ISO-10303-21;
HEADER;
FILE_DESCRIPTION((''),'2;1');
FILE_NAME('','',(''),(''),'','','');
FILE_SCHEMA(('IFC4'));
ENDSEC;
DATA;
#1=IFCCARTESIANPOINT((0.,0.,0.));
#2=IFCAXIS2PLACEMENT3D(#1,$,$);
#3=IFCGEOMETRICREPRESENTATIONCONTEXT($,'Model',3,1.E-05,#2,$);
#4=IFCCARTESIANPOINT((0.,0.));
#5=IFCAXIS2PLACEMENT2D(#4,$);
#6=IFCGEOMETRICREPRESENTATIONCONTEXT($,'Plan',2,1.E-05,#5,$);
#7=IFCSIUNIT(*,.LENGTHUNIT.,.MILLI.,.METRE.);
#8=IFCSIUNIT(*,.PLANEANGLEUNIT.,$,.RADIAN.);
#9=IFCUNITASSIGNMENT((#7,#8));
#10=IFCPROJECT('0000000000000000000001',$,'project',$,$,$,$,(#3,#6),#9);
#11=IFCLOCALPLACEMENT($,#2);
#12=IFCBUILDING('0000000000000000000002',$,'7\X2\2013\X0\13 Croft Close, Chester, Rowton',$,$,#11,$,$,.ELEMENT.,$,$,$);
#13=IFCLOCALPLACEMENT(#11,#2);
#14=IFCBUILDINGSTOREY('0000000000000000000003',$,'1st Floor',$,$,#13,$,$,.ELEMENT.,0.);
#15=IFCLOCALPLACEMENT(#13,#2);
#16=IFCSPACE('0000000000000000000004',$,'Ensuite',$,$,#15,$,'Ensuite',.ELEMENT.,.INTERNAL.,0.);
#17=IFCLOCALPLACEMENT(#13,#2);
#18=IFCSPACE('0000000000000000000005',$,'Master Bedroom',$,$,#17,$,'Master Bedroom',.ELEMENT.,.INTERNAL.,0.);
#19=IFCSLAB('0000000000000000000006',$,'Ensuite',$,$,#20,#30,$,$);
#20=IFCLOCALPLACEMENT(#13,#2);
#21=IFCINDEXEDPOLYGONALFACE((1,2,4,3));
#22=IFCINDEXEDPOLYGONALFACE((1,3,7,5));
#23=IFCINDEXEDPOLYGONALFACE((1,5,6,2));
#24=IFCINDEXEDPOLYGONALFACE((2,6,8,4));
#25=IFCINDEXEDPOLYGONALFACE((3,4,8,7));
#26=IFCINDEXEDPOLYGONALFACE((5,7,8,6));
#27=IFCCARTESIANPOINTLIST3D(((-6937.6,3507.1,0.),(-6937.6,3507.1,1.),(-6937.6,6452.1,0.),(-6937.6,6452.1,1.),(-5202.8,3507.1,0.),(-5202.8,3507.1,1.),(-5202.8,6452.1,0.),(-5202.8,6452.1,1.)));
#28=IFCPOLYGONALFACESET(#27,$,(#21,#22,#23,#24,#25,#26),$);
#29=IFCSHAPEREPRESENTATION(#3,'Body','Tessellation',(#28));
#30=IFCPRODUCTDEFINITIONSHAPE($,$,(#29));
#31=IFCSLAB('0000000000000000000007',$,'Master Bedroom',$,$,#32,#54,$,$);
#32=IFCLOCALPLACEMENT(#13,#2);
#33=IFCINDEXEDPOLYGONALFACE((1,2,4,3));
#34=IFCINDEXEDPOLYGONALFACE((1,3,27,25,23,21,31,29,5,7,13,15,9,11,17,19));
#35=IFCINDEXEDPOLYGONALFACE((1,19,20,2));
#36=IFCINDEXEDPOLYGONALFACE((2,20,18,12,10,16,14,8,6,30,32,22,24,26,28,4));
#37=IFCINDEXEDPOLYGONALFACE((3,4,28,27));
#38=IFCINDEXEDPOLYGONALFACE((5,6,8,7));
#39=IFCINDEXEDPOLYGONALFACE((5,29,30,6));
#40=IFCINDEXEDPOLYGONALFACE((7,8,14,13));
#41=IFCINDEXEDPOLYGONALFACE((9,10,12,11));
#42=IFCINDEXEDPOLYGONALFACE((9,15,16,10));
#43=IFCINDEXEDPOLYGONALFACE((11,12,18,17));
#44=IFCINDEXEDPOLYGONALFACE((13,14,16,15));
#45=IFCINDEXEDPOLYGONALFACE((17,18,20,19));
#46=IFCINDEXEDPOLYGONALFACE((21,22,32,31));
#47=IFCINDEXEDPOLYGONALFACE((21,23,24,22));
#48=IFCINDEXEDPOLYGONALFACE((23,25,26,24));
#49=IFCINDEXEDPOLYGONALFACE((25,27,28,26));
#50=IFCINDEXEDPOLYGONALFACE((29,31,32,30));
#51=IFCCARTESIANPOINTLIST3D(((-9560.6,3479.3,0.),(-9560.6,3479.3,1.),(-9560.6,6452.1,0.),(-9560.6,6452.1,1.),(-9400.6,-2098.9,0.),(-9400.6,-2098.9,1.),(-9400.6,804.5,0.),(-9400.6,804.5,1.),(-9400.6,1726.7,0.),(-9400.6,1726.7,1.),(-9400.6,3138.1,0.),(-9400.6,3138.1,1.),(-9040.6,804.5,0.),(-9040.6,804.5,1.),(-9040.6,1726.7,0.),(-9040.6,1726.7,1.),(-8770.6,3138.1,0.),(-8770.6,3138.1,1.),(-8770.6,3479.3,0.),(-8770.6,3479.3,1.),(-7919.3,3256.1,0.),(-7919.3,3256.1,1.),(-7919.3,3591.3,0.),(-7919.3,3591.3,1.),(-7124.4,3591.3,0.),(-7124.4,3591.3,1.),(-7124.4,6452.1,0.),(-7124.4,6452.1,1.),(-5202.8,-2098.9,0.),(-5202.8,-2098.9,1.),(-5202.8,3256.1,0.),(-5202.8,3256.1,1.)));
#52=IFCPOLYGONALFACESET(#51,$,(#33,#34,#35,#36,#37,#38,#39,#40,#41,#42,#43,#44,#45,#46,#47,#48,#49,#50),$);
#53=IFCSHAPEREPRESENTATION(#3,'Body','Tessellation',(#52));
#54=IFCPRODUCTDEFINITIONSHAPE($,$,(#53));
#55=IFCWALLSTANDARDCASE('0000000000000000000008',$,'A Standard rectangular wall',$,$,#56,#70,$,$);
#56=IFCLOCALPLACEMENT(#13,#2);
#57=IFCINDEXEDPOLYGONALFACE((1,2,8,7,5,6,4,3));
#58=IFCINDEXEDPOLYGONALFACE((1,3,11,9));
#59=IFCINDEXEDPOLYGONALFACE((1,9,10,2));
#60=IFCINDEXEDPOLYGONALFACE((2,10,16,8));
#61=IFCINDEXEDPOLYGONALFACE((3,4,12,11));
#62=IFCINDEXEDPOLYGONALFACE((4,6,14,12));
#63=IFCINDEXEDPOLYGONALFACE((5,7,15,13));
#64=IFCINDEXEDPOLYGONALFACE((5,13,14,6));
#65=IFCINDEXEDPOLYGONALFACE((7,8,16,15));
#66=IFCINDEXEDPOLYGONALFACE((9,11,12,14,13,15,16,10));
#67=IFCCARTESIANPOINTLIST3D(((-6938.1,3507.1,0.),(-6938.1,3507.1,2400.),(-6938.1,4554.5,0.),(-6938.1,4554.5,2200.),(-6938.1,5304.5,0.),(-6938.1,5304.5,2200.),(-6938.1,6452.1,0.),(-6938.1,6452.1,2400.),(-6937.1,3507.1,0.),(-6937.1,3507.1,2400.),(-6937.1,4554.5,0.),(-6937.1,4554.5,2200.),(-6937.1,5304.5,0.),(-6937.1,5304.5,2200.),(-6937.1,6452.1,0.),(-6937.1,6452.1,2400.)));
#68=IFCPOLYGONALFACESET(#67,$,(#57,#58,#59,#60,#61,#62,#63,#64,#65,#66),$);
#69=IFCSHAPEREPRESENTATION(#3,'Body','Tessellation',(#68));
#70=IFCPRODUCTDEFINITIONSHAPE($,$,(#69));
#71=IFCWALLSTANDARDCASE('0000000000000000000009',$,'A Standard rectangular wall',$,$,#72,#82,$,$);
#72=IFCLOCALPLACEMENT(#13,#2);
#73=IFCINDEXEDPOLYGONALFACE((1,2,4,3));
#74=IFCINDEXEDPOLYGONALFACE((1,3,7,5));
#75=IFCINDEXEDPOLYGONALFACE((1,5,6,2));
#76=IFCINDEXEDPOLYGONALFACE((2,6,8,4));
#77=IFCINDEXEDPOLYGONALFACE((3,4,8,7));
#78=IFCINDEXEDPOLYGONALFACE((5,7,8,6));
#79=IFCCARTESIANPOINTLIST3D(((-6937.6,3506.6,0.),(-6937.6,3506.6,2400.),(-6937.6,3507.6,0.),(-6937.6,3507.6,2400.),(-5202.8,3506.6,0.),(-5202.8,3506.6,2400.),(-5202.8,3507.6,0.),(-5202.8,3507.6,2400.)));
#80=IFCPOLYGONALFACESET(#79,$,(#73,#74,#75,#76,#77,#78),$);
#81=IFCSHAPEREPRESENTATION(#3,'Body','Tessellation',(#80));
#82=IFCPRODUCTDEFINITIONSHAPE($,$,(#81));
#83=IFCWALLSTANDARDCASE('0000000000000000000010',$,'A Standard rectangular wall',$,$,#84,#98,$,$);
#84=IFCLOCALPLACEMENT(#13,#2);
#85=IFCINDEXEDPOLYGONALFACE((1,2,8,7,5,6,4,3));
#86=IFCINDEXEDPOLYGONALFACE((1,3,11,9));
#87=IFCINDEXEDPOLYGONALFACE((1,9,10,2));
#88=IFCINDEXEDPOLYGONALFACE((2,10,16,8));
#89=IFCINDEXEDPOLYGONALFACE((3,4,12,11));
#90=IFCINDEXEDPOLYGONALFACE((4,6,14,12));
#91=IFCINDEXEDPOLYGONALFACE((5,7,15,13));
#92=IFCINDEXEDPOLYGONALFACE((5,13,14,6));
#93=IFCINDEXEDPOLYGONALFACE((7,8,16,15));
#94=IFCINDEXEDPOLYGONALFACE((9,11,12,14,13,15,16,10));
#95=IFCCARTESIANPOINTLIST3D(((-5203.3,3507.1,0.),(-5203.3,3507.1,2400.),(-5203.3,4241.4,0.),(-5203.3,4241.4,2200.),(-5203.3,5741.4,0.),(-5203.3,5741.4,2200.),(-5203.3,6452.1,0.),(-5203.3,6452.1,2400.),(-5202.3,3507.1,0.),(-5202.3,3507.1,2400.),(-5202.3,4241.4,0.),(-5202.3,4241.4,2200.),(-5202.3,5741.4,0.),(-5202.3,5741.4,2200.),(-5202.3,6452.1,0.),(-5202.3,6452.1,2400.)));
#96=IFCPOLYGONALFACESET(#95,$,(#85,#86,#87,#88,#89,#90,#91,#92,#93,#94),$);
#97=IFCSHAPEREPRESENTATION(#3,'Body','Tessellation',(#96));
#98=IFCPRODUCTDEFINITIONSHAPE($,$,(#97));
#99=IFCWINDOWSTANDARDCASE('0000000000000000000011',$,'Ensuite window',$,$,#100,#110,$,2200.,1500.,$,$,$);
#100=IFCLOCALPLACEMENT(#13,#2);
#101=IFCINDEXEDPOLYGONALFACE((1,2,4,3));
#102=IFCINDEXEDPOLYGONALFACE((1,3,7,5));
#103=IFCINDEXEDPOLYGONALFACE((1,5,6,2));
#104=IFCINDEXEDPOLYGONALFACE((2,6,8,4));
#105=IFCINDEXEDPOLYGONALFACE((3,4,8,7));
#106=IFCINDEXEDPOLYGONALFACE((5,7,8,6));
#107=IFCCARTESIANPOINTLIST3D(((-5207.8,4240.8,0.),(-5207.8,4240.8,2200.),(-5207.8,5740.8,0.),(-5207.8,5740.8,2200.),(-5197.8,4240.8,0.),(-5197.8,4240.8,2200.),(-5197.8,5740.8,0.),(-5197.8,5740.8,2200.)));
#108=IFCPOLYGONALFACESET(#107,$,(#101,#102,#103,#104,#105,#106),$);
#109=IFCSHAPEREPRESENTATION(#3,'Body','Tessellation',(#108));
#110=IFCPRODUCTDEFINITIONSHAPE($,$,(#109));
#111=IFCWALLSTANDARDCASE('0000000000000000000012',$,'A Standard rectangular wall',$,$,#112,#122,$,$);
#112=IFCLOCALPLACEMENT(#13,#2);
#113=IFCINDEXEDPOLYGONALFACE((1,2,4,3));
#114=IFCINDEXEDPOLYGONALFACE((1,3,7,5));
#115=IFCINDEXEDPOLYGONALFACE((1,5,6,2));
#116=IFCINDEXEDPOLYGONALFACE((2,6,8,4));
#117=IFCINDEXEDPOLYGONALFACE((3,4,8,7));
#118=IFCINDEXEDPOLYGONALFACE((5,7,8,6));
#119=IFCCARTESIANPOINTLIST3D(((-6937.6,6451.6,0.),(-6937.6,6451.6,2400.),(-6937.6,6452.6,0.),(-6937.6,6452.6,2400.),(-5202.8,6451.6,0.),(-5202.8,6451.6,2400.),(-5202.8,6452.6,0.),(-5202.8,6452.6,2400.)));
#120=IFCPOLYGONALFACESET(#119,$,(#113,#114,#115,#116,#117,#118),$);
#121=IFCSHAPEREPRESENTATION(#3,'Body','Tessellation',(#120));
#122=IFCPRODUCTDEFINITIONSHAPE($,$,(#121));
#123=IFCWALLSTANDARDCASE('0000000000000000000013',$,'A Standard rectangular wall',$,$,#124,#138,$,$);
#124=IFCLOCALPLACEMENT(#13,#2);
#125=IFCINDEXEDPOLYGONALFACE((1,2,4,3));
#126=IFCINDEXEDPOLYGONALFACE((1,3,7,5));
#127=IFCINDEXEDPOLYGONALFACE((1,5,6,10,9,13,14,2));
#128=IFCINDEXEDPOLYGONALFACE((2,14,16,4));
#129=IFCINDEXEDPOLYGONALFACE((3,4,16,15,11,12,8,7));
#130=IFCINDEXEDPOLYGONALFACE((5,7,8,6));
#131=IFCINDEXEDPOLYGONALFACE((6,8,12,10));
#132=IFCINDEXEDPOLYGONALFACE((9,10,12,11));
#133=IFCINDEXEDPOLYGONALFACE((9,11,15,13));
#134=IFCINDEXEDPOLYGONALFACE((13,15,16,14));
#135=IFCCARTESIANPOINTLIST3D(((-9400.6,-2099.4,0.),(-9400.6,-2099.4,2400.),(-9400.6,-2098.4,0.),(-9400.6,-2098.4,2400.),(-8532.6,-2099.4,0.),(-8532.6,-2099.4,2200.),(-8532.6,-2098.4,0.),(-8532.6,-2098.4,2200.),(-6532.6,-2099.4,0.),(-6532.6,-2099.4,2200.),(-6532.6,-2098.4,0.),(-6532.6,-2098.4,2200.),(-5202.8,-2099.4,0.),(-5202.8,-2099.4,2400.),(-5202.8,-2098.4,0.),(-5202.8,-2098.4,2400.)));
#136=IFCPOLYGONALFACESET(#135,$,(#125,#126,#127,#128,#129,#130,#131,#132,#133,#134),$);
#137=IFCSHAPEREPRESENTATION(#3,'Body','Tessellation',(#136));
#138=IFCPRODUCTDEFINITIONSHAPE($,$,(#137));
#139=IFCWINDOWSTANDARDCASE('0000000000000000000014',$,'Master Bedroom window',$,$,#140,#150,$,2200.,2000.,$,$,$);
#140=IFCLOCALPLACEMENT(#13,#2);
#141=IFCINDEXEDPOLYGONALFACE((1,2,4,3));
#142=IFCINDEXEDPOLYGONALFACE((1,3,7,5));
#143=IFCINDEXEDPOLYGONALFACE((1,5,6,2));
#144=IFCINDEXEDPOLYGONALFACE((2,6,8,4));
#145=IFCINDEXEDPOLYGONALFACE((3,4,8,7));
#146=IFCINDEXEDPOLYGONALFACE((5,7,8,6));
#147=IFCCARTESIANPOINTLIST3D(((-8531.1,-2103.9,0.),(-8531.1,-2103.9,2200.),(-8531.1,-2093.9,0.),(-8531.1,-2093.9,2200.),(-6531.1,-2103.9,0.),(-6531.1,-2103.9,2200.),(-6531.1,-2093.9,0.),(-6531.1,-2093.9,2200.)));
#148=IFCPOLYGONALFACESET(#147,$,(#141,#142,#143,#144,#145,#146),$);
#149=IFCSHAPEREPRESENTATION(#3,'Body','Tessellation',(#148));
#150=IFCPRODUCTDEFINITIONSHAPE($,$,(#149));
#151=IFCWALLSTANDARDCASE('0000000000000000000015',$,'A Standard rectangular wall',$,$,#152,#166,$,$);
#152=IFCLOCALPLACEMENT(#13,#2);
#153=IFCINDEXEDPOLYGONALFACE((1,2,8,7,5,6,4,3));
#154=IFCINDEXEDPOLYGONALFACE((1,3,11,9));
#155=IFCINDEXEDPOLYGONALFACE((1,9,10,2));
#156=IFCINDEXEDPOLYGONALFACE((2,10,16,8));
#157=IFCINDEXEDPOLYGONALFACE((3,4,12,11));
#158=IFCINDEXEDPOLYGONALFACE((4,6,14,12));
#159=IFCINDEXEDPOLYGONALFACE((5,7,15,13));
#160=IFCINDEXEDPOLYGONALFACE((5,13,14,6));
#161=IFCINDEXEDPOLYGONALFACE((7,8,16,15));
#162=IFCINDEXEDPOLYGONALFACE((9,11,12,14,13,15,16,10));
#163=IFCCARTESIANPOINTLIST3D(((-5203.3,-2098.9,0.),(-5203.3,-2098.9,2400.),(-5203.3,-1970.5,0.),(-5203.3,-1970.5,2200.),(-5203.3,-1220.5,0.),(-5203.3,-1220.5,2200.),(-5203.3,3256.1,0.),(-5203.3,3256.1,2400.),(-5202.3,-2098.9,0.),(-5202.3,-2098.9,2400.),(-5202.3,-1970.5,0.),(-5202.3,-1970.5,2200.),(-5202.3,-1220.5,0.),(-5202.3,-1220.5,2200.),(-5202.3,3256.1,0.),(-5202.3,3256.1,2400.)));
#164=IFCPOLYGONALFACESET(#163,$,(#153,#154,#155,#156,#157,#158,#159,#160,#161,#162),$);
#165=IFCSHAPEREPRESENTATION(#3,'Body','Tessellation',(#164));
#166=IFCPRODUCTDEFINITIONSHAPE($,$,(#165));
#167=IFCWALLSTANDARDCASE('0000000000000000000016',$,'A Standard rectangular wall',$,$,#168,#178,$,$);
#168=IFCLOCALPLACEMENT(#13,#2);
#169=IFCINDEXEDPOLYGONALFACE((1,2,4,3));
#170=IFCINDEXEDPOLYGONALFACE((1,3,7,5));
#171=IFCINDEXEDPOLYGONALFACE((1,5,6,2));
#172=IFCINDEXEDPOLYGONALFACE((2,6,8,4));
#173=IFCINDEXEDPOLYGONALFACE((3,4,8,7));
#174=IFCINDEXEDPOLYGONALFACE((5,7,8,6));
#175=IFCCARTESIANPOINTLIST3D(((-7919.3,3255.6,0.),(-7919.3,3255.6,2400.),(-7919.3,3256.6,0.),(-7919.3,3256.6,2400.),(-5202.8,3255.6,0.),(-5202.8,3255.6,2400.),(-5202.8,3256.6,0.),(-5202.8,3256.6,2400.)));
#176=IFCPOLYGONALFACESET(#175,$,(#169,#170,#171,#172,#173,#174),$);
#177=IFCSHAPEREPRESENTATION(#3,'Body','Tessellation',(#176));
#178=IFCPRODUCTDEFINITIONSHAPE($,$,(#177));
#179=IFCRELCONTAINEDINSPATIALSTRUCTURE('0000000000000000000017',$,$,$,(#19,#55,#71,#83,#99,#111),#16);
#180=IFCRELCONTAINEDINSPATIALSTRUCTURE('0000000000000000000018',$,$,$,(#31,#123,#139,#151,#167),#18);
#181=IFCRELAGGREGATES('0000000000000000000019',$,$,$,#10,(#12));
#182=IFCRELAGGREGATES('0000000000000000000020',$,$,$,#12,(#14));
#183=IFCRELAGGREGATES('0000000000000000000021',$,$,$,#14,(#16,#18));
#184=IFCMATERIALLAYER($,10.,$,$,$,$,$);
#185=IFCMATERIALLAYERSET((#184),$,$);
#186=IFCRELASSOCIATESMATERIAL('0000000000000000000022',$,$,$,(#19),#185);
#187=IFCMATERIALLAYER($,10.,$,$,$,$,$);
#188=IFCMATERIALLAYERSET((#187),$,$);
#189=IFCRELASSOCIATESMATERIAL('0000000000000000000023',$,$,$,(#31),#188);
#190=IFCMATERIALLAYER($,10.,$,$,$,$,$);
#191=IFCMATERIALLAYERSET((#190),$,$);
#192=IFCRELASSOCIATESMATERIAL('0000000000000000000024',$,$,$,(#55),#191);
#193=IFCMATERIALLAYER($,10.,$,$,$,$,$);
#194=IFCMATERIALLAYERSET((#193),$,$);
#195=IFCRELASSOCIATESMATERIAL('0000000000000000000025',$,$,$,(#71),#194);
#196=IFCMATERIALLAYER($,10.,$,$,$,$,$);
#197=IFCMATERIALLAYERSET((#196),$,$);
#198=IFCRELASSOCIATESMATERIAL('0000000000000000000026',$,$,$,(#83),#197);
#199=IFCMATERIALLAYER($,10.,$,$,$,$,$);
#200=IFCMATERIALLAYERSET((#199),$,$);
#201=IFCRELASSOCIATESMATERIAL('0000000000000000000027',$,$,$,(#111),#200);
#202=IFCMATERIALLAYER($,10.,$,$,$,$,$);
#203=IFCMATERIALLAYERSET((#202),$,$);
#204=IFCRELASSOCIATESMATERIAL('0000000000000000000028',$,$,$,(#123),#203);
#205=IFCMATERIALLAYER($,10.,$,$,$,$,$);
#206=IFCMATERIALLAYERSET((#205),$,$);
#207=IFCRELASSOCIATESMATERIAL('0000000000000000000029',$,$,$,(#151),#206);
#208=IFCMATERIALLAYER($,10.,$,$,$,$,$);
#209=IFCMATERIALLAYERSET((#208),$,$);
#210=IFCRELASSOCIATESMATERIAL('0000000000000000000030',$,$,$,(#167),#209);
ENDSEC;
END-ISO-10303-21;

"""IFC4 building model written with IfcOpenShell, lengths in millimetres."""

from ifc_helpers import new_model, si_unit, frame, origin, origin_2d, place, context, project, spatial, polyline, rectangle, outline, extrude, layer, layer_set, layer_usage, element, fill, save


model = new_model("IFC4")

# Units and contexts
model_context = context("Model", 3, precision=1e-05, world=origin())
plan_context = context("Plan", 2, precision=1e-05, world=origin_2d())
ifc_project = project(units=[si_unit("LENGTHUNIT", "METRE", prefix="MILLI"), si_unit("PLANEANGLEUNIT", "RADIAN")], contexts=[model_context, plan_context])

# Building, storey, space
building_placement = place(None, origin())
building = spatial("IfcBuilding", under=ifc_project, at=building_placement, Name="7–13 Croft Close, Chester, Rowton", CompositionType="ELEMENT")
storey_placement = place(building_placement, origin())
storey = spatial("IfcBuildingStorey", under=building, at=storey_placement, Name="1st Floor", CompositionType="ELEMENT", Elevation=0.0)
space_1_placement = place(storey_placement, origin())
space_1 = spatial("IfcSpace", under=storey, at=space_1_placement, Name="Ensuite", LongName="Ensuite", CompositionType="ELEMENT", PredefinedType="INTERNAL", ElevationWithFlooring=0.0)

# Slab
ifc_layer_1 = layer(None, 10.0)
ifc_layer_set_1 = layer_set([ifc_layer_1])
ifc_layer_usage_1 = layer_usage(ifc_layer_set_1, "AXIS2", "NEGATIVE", 150.0)
slab_1_placement = place(storey_placement, origin())
element("IfcSlab", 1, at=slab_1_placement, inside=space_1, material=ifc_layer_usage_1, Name="Ensuite", context=model_context, shape_type="SweptSolid", body=[
    extrude(outline(polyline([(-6937.6, 6452.1), (-6937.6, 3507.1), (-5202.8, 3507.1), (-5202.8, 6452.1), (-6937.6, 6452.1)])), origin(), (0.0, 0.0, 1.0), 1.0),
])

# Shared definitions
space_2_placement = place(storey_placement, origin())
space_2 = spatial("IfcSpace", under=storey, at=space_2_placement, Name="Master Bedroom", LongName="Master Bedroom", CompositionType="ELEMENT", PredefinedType="INTERNAL", ElevationWithFlooring=0.0)

# Slab
ifc_layer_2 = layer(None, 10.0)
ifc_layer_set_2 = layer_set([ifc_layer_2])
ifc_layer_usage_2 = layer_usage(ifc_layer_set_2, "AXIS2", "NEGATIVE", 150.0)
slab_2_placement = place(storey_placement, origin())
element("IfcSlab", 2, at=slab_2_placement, inside=space_2, material=ifc_layer_usage_2, Name="Master Bedroom", context=model_context, shape_type="SweptSolid", body=[
    extrude(outline(polyline([(-9400.6, -2098.9), (-5202.8, -2098.9), (-5202.8, 3256.1), (-7919.3, 3256.1), (-7919.3, 3591.3), (-7124.4, 3591.3), (-7124.4, 6452.1), (-9560.6, 6452.1), (-9560.6, 3479.3), (-8770.6, 3479.3), (-8770.6, 3138.1), (-9400.6, 3138.1), (-9400.6, 1726.7), (-9040.6, 1726.7), (-9040.6, 804.5), (-9400.6, 804.5), (-9400.6, -2098.9)])), origin(), (0.0, 0.0, 1.0), 1.0),
])

# Wall, opening
ifc_layer_3 = layer(None, 10.0)
ifc_layer_set_3 = layer_set([ifc_layer_3])
ifc_layer_usage_3 = layer_usage(ifc_layer_set_3, "AXIS2", "NEGATIVE", 150.0)
wall_1_placement = place(storey_placement, origin())
wall_1 = element("IfcWallStandardCase", 3, at=wall_1_placement, inside=space_1, material=ifc_layer_usage_3, Name="A Standard rectangular wall", context=model_context, shape_type="SweptSolid", body=[
    extrude(rectangle(XDim=1.0, YDim=2945.0, at=origin_2d()), frame((-6937.6, 4979.6, 0.0), x_axis=(1.0, 0.0, 0.0)), (0.0, 0.0, 1.0), 2400.0),
])
opening_1_placement = place(storey_placement, origin())
element("IfcOpeningElement", 4, at=opening_1_placement, cuts=wall_1, context=model_context, shape_type="SweptSolid", body=[
    extrude(rectangle(XDim=10.0, YDim=750.0, at=origin_2d()), frame((-6937.6, 4929.5, 0.0), x_axis=(-1.0, 0.0, 0.0)), (0.0, 0.0, 1.0), 2200.0),
])

# Wall
ifc_layer_4 = layer(None, 10.0)
ifc_layer_set_4 = layer_set([ifc_layer_4])
ifc_layer_usage_4 = layer_usage(ifc_layer_set_4, "AXIS2", "NEGATIVE", 150.0)
wall_2_placement = place(storey_placement, origin())
element("IfcWallStandardCase", 5, at=wall_2_placement, inside=space_1, material=ifc_layer_usage_4, Name="A Standard rectangular wall", context=model_context, shape_type="SweptSolid", body=[
    extrude(rectangle(XDim=1.0, YDim=1734.8, at=origin_2d()), frame((-6070.2, 3507.1, 0.0), x_axis=(0.0, 1.0, 0.0)), (0.0, 0.0, 1.0), 2400.0),
])

# Wall, opening, window
ifc_layer_5 = layer(None, 10.0)
ifc_layer_set_5 = layer_set([ifc_layer_5])
ifc_layer_usage_5 = layer_usage(ifc_layer_set_5, "AXIS2", "NEGATIVE", 150.0)
wall_3_placement = place(storey_placement, origin())
wall_3 = element("IfcWallStandardCase", 6, at=wall_3_placement, inside=space_1, material=ifc_layer_usage_5, Name="A Standard rectangular wall", context=model_context, shape_type="SweptSolid", body=[
    extrude(rectangle(XDim=1.0, YDim=2945.0, at=origin_2d()), frame((-5202.8, 4979.6, 0.0), x_axis=(-1.0, 0.0, 0.0)), (0.0, 0.0, 1.0), 2400.0),
])
opening_2_placement = place(storey_placement, origin())
opening_2 = element("IfcOpeningElement", 7, at=opening_2_placement, cuts=wall_3, context=model_context, shape_type="SweptSolid", body=[
    extrude(rectangle(XDim=10.0, YDim=1500.0, at=origin_2d()), frame((-5202.8, 4991.4, 0.0), x_axis=(-1.0, 0.0, 0.0)), (0.0, 0.0, 1.0), 2200.0),
])
window_1_placement = place(storey_placement, frame((0.0, -0.6, 0.0)))
window_1 = element("IfcWindowStandardCase", 8, at=window_1_placement, inside=space_1, Name="Ensuite window", OverallHeight=2200.0, OverallWidth=1500.0, context=model_context, shape_type="SweptSolid", body=[
    extrude(rectangle(XDim=10.0, YDim=1500.0, at=origin_2d()), frame((-5202.8, 4991.4, 0.0), x_axis=(-1.0, 0.0, 0.0)), (0.0, 0.0, 1.0), 2200.0),
])
fill(opening_2, window_1)

# Wall
ifc_layer_6 = layer(None, 10.0)
ifc_layer_set_6 = layer_set([ifc_layer_6])
ifc_layer_usage_6 = layer_usage(ifc_layer_set_6, "AXIS2", "NEGATIVE", 150.0)
wall_4_placement = place(storey_placement, origin())
element("IfcWallStandardCase", 9, at=wall_4_placement, inside=space_1, material=ifc_layer_usage_6, Name="A Standard rectangular wall", context=model_context, shape_type="SweptSolid", body=[
    extrude(rectangle(XDim=1.0, YDim=1734.8, at=origin_2d()), frame((-6070.2, 6452.1, 0.0), x_axis=(0.0, -1.0, 0.0)), (0.0, 0.0, 1.0), 2400.0),
])

# Wall, opening, window
ifc_layer_7 = layer(None, 10.0)
ifc_layer_set_7 = layer_set([ifc_layer_7])
ifc_layer_usage_7 = layer_usage(ifc_layer_set_7, "AXIS2", "NEGATIVE", 150.0)
wall_5_placement = place(storey_placement, origin())
wall_5 = element("IfcWallStandardCase", 10, at=wall_5_placement, inside=space_2, material=ifc_layer_usage_7, Name="A Standard rectangular wall", context=model_context, shape_type="SweptSolid", body=[
    extrude(rectangle(XDim=1.0, YDim=4197.8, at=origin_2d()), frame((-7301.7, -2098.9, 0.0), x_axis=(0.0, 1.0, 0.0)), (0.0, 0.0, 1.0), 2400.0),
])
opening_3_placement = place(storey_placement, origin())
opening_3 = element("IfcOpeningElement", 11, at=opening_3_placement, cuts=wall_5, context=model_context, shape_type="SweptSolid", body=[
    extrude(rectangle(XDim=10.0, YDim=2000.0, at=origin_2d()), frame((-7532.6, -2098.9, 0.0), x_axis=(0.0, 1.0, 0.0)), (0.0, 0.0, 1.0), 2200.0),
])
window_2_placement = place(storey_placement, frame((1.5, 0.0, 0.0)))
window_2 = element("IfcWindowStandardCase", 12, at=window_2_placement, inside=space_2, Name="Master Bedroom window", OverallHeight=2200.0, OverallWidth=2000.0, context=model_context, shape_type="SweptSolid", body=[
    extrude(rectangle(XDim=10.0, YDim=2000.0, at=origin_2d()), frame((-7532.6, -2098.9, 0.0), x_axis=(0.0, 1.0, 0.0)), (0.0, 0.0, 1.0), 2200.0),
])
fill(opening_3, window_2)

# Wall, opening
ifc_layer_8 = layer(None, 10.0)
ifc_layer_set_8 = layer_set([ifc_layer_8])
ifc_layer_usage_8 = layer_usage(ifc_layer_set_8, "AXIS2", "NEGATIVE", 150.0)
wall_6_placement = place(storey_placement, origin())
wall_6 = element("IfcWallStandardCase", 13, at=wall_6_placement, inside=space_2, material=ifc_layer_usage_8, Name="A Standard rectangular wall", context=model_context, shape_type="SweptSolid", body=[
    extrude(rectangle(XDim=1.0, YDim=5355.0, at=origin_2d()), frame((-5202.8, 578.6, 0.0), x_axis=(-1.0, 0.0, 0.0)), (0.0, 0.0, 1.0), 2400.0),
])
opening_4_placement = place(storey_placement, origin())
element("IfcOpeningElement", 14, at=opening_4_placement, cuts=wall_6, context=model_context, shape_type="SweptSolid", body=[
    extrude(rectangle(XDim=10.0, YDim=750.0, at=origin_2d()), frame((-5202.8, -1595.5, 0.0), x_axis=(1.0, 0.0, 0.0)), (0.0, 0.0, 1.0), 2200.0),
])

# Wall
ifc_layer_9 = layer(None, 10.0)
ifc_layer_set_9 = layer_set([ifc_layer_9])
ifc_layer_usage_9 = layer_usage(ifc_layer_set_9, "AXIS2", "NEGATIVE", 150.0)
wall_7_placement = place(storey_placement, origin())
element("IfcWallStandardCase", 15, at=wall_7_placement, inside=space_2, material=ifc_layer_usage_9, Name="A Standard rectangular wall", context=model_context, shape_type="SweptSolid", body=[
    extrude(rectangle(XDim=1.0, YDim=2716.5, at=origin_2d()), frame((-6561.0, 3256.1, 0.0), x_axis=(0.0, -1.0, 0.0)), (0.0, 0.0, 1.0), 2400.0),
])

save(model, "model.ifc")
